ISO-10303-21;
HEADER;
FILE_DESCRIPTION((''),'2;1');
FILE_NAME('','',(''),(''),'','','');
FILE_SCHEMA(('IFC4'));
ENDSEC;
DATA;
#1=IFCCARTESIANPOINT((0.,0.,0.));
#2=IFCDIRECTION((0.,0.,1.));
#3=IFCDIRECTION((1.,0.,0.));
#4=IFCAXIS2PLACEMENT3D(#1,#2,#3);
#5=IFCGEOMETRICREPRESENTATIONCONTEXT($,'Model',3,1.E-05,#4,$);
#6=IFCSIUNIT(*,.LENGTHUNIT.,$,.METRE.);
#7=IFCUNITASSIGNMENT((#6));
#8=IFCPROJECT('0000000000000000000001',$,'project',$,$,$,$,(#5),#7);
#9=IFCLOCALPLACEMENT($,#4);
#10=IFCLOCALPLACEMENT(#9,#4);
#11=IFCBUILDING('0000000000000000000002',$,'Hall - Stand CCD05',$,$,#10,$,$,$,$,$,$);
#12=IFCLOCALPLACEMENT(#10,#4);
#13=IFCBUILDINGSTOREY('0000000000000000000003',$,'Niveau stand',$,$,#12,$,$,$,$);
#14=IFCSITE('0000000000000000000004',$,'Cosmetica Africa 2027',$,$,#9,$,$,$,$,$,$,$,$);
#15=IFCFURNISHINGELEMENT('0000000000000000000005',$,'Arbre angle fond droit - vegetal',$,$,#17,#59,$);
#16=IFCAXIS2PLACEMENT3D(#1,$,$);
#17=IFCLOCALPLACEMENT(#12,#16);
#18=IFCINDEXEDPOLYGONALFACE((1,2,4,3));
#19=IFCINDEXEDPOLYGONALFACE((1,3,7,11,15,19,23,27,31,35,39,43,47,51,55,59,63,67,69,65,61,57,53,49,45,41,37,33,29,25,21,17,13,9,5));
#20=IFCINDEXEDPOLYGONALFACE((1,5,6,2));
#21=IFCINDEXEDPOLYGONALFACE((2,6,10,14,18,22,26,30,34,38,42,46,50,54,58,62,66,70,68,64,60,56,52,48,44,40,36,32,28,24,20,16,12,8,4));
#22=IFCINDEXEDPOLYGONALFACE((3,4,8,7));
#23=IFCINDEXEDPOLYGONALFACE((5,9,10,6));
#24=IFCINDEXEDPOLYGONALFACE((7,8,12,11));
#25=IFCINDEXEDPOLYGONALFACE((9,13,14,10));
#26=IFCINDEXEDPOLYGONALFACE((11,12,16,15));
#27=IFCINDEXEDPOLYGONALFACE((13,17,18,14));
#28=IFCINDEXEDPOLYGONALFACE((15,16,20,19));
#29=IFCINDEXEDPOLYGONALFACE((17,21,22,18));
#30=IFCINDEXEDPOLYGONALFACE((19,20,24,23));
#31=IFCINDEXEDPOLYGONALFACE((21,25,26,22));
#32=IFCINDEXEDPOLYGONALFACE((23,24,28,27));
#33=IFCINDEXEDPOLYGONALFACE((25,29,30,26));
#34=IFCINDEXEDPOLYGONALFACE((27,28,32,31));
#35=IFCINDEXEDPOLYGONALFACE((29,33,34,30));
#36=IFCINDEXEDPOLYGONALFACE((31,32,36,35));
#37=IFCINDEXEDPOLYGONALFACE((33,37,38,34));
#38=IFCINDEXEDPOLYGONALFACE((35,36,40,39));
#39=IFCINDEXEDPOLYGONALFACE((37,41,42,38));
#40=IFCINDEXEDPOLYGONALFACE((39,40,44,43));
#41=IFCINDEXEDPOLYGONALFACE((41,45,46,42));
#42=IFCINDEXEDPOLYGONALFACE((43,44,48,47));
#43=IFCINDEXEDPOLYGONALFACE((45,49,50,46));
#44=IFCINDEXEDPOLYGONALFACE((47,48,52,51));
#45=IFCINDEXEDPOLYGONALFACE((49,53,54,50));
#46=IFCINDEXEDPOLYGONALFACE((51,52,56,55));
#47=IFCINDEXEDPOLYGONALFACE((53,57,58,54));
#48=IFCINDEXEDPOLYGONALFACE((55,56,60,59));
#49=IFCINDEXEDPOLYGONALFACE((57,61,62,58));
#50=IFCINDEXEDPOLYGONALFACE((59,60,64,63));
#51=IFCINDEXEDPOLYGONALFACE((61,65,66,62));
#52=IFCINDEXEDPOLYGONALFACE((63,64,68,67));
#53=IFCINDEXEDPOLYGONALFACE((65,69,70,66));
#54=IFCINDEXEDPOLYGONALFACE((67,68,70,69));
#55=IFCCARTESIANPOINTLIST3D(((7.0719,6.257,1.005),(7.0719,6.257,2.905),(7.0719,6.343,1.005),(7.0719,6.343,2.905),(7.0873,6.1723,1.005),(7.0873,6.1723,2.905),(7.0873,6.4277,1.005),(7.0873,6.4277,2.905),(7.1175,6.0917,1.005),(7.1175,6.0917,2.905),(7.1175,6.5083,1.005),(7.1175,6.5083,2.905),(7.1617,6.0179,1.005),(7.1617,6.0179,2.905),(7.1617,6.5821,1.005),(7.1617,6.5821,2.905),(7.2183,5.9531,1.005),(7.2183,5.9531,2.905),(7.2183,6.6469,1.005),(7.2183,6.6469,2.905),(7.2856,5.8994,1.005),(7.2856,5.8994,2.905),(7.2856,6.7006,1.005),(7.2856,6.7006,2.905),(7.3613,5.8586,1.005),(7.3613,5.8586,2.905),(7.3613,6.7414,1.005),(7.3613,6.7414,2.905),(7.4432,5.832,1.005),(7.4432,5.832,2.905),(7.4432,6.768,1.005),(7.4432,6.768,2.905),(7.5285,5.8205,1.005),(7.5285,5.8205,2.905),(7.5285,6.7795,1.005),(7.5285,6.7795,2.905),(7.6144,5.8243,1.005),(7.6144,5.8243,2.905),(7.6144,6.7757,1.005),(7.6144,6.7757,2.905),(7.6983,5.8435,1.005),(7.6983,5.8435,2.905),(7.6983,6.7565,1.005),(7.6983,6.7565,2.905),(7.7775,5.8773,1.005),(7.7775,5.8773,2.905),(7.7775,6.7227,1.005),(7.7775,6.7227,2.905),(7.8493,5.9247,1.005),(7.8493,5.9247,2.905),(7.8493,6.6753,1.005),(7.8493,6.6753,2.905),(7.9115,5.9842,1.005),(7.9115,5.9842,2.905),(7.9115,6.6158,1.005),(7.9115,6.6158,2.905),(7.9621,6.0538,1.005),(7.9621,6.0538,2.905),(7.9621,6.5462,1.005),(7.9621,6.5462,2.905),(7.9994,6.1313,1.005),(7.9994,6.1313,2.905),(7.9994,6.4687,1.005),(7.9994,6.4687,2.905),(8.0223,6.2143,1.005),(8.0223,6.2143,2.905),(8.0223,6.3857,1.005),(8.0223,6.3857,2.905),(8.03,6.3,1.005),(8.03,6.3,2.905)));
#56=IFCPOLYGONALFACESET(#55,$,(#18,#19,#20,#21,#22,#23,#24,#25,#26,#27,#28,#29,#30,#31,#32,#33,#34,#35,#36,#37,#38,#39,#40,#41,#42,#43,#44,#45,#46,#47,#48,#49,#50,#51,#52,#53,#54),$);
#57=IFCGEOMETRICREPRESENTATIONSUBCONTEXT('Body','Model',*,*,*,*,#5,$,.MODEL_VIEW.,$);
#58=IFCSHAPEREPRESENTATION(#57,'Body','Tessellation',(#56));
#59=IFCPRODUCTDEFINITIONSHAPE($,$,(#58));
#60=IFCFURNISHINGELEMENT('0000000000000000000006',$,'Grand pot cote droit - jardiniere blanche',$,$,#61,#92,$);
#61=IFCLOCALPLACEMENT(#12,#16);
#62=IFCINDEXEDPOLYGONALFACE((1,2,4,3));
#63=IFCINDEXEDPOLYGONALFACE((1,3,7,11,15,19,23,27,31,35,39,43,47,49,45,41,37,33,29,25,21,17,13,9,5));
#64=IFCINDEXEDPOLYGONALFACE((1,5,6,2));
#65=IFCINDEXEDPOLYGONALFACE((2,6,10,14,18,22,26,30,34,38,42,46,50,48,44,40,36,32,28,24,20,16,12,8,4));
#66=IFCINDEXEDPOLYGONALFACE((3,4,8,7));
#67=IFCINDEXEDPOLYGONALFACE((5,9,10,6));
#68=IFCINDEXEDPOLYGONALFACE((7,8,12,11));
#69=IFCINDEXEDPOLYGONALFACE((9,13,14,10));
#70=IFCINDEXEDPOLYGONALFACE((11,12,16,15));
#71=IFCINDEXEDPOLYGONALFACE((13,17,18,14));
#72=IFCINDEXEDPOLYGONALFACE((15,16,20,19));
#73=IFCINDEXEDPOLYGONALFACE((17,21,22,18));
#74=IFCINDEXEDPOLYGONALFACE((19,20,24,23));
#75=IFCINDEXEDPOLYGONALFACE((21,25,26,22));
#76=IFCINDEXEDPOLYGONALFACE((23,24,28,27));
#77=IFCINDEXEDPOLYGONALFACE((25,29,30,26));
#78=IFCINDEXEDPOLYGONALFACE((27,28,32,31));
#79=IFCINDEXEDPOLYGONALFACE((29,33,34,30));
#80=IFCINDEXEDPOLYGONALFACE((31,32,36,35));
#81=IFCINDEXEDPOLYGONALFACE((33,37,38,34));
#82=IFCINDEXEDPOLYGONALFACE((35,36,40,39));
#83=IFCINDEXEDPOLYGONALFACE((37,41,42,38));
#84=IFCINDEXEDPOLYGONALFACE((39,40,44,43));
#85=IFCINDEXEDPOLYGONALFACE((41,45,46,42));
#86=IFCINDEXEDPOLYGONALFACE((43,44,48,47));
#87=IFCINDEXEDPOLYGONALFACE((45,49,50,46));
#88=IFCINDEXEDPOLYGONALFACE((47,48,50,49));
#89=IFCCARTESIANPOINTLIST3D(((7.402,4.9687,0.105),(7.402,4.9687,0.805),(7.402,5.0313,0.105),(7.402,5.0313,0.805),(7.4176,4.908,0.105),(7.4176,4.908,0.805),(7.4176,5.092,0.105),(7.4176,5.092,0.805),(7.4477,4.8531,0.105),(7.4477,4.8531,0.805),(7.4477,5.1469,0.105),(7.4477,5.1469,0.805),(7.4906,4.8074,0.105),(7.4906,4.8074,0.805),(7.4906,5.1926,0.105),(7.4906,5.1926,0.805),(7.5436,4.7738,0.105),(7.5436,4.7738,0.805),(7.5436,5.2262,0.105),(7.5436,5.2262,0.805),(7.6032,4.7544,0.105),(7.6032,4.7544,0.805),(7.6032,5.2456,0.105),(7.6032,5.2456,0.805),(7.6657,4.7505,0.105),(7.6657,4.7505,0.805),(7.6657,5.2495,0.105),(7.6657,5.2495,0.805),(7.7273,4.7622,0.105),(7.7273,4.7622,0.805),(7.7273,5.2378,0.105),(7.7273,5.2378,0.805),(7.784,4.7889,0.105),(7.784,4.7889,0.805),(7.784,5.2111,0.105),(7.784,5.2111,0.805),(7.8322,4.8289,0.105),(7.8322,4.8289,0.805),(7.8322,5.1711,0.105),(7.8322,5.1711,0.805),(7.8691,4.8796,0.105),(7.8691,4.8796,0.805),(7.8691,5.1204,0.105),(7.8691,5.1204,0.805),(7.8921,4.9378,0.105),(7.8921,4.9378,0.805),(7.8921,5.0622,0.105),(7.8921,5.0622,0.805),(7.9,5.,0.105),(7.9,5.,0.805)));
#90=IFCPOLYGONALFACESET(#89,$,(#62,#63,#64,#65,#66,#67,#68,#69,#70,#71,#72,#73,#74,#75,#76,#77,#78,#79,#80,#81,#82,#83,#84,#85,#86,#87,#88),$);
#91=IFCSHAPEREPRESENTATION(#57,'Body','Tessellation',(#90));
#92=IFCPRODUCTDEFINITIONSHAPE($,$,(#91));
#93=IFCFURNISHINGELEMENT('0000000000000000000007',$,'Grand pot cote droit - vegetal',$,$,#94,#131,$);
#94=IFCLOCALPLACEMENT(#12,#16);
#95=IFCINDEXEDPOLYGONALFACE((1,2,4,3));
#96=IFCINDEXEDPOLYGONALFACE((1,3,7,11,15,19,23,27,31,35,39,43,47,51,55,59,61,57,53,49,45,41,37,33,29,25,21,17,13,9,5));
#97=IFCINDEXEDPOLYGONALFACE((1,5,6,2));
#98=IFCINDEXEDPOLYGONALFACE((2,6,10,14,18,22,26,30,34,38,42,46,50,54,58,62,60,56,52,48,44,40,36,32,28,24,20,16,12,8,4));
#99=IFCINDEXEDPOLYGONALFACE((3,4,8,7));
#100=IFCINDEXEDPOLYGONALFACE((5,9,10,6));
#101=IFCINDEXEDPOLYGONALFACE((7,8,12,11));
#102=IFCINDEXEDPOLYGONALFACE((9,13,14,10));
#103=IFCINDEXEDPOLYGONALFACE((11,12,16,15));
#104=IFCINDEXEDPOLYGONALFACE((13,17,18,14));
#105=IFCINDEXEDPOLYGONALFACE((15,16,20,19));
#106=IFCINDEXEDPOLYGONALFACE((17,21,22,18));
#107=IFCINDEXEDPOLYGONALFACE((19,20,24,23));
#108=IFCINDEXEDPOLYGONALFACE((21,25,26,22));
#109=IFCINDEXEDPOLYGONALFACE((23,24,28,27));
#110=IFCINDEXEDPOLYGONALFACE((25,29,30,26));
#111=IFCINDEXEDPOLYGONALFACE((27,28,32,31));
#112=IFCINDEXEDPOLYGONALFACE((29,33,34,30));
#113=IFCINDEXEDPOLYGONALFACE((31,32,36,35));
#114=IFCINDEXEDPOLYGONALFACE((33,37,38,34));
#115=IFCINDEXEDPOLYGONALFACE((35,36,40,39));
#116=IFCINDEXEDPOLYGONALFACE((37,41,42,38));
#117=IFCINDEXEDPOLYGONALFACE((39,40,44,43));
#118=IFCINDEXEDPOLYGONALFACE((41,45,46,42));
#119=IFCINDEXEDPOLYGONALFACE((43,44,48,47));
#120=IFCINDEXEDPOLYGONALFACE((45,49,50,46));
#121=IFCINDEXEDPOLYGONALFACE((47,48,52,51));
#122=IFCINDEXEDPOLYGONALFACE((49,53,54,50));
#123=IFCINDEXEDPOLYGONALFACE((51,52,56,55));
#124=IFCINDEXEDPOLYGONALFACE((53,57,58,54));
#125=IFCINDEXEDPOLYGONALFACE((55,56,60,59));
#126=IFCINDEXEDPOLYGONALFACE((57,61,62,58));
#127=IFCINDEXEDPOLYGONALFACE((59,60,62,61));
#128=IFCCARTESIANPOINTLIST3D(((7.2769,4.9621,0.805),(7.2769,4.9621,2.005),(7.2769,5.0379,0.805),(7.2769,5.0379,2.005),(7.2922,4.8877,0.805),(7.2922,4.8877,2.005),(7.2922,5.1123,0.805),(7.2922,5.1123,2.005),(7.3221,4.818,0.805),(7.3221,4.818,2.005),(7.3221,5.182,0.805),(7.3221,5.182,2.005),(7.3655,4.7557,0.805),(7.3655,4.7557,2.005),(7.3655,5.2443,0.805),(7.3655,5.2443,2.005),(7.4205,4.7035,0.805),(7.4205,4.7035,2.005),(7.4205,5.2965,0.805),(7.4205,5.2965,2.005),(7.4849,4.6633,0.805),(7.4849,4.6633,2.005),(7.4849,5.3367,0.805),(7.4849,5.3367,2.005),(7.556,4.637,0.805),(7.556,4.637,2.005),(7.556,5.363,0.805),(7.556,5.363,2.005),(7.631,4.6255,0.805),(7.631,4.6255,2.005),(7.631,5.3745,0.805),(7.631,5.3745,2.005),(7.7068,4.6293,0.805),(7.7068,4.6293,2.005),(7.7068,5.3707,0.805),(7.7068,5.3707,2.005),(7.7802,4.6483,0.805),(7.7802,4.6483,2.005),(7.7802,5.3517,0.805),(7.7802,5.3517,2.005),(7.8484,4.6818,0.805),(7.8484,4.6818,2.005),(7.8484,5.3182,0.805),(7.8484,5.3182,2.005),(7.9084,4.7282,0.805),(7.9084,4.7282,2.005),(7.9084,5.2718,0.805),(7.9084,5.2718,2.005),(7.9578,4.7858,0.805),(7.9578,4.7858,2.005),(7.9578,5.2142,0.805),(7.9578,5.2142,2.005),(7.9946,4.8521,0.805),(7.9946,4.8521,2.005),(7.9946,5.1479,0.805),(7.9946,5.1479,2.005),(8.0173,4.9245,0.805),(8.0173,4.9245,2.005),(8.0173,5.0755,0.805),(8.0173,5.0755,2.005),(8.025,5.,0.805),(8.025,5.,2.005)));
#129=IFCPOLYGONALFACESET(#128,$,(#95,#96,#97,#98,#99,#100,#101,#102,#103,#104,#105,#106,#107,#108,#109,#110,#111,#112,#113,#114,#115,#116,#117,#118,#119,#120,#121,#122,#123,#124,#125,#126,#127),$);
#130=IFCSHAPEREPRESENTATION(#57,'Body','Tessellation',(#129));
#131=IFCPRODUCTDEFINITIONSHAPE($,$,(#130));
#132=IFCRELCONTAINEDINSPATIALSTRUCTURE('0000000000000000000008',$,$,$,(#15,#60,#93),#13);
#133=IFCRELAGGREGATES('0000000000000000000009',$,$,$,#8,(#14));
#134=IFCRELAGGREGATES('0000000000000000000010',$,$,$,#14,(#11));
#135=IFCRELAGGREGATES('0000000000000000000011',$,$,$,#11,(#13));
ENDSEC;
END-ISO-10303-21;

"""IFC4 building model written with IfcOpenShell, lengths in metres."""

from ifc_helpers import new_model, si_unit, frame, frame_2d, origin_with_axes, place, context, subcontext, project, spatial, circle, extrude, element, save


model = new_model("IFC4")

# Units and contexts
model_context = context("Model", 3, precision=1e-05, world=origin_with_axes())
body_context = subcontext(model_context, "Body", "Model", "MODEL_VIEW")
ifc_project = project(units=[si_unit("LENGTHUNIT", "METRE")], contexts=[model_context])

# Site, building, storey
site_placement = place(None, origin_with_axes())
site = spatial("IfcSite", under=ifc_project, at=site_placement, Name="Cosmetica Africa 2027")
building_placement = place(site_placement, origin_with_axes())
building = spatial("IfcBuilding", under=site, at=building_placement, Name="Hall - Stand CCD05")
storey_placement = place(building_placement, origin_with_axes())
storey = spatial("IfcBuildingStorey", under=building, at=storey_placement, Name="Niveau stand")

# Furnishing elements
furnishing_1_placement = place(storey_placement, origin_with_axes())
element("IfcFurnishingElement", 1, at=furnishing_1_placement, inside=storey, Name="Arbre angle fond droit - vegetal", context=body_context, shape_type="SweptSolid", body=[
    extrude(circle(Radius=0.48, at=frame_2d((7.55, 6.3))), frame((0.0, 0.0, 1.005)), (0.0, 0.0, 1.0), 1.9),
])
furnishing_2_placement = place(storey_placement, origin_with_axes())
element("IfcFurnishingElement", 2, at=furnishing_2_placement, inside=storey, Name="Grand pot cote droit - jardiniere blanche", context=body_context, shape_type="SweptSolid", body=[
    extrude(circle(Radius=0.25, at=frame_2d((7.65, 5.0))), frame((0.0, 0.0, 0.105)), (0.0, 0.0, 1.0), 0.7),
])
furnishing_3_placement = place(storey_placement, origin_with_axes())
element("IfcFurnishingElement", 3, at=furnishing_3_placement, inside=storey, Name="Grand pot cote droit - vegetal", context=body_context, shape_type="SweptSolid", body=[
    extrude(circle(Radius=0.375, at=frame_2d((7.65, 5.0))), frame((0.0, 0.0, 0.805)), (0.0, 0.0, 1.0), 1.2),
])

save(model, "model.ifc")
